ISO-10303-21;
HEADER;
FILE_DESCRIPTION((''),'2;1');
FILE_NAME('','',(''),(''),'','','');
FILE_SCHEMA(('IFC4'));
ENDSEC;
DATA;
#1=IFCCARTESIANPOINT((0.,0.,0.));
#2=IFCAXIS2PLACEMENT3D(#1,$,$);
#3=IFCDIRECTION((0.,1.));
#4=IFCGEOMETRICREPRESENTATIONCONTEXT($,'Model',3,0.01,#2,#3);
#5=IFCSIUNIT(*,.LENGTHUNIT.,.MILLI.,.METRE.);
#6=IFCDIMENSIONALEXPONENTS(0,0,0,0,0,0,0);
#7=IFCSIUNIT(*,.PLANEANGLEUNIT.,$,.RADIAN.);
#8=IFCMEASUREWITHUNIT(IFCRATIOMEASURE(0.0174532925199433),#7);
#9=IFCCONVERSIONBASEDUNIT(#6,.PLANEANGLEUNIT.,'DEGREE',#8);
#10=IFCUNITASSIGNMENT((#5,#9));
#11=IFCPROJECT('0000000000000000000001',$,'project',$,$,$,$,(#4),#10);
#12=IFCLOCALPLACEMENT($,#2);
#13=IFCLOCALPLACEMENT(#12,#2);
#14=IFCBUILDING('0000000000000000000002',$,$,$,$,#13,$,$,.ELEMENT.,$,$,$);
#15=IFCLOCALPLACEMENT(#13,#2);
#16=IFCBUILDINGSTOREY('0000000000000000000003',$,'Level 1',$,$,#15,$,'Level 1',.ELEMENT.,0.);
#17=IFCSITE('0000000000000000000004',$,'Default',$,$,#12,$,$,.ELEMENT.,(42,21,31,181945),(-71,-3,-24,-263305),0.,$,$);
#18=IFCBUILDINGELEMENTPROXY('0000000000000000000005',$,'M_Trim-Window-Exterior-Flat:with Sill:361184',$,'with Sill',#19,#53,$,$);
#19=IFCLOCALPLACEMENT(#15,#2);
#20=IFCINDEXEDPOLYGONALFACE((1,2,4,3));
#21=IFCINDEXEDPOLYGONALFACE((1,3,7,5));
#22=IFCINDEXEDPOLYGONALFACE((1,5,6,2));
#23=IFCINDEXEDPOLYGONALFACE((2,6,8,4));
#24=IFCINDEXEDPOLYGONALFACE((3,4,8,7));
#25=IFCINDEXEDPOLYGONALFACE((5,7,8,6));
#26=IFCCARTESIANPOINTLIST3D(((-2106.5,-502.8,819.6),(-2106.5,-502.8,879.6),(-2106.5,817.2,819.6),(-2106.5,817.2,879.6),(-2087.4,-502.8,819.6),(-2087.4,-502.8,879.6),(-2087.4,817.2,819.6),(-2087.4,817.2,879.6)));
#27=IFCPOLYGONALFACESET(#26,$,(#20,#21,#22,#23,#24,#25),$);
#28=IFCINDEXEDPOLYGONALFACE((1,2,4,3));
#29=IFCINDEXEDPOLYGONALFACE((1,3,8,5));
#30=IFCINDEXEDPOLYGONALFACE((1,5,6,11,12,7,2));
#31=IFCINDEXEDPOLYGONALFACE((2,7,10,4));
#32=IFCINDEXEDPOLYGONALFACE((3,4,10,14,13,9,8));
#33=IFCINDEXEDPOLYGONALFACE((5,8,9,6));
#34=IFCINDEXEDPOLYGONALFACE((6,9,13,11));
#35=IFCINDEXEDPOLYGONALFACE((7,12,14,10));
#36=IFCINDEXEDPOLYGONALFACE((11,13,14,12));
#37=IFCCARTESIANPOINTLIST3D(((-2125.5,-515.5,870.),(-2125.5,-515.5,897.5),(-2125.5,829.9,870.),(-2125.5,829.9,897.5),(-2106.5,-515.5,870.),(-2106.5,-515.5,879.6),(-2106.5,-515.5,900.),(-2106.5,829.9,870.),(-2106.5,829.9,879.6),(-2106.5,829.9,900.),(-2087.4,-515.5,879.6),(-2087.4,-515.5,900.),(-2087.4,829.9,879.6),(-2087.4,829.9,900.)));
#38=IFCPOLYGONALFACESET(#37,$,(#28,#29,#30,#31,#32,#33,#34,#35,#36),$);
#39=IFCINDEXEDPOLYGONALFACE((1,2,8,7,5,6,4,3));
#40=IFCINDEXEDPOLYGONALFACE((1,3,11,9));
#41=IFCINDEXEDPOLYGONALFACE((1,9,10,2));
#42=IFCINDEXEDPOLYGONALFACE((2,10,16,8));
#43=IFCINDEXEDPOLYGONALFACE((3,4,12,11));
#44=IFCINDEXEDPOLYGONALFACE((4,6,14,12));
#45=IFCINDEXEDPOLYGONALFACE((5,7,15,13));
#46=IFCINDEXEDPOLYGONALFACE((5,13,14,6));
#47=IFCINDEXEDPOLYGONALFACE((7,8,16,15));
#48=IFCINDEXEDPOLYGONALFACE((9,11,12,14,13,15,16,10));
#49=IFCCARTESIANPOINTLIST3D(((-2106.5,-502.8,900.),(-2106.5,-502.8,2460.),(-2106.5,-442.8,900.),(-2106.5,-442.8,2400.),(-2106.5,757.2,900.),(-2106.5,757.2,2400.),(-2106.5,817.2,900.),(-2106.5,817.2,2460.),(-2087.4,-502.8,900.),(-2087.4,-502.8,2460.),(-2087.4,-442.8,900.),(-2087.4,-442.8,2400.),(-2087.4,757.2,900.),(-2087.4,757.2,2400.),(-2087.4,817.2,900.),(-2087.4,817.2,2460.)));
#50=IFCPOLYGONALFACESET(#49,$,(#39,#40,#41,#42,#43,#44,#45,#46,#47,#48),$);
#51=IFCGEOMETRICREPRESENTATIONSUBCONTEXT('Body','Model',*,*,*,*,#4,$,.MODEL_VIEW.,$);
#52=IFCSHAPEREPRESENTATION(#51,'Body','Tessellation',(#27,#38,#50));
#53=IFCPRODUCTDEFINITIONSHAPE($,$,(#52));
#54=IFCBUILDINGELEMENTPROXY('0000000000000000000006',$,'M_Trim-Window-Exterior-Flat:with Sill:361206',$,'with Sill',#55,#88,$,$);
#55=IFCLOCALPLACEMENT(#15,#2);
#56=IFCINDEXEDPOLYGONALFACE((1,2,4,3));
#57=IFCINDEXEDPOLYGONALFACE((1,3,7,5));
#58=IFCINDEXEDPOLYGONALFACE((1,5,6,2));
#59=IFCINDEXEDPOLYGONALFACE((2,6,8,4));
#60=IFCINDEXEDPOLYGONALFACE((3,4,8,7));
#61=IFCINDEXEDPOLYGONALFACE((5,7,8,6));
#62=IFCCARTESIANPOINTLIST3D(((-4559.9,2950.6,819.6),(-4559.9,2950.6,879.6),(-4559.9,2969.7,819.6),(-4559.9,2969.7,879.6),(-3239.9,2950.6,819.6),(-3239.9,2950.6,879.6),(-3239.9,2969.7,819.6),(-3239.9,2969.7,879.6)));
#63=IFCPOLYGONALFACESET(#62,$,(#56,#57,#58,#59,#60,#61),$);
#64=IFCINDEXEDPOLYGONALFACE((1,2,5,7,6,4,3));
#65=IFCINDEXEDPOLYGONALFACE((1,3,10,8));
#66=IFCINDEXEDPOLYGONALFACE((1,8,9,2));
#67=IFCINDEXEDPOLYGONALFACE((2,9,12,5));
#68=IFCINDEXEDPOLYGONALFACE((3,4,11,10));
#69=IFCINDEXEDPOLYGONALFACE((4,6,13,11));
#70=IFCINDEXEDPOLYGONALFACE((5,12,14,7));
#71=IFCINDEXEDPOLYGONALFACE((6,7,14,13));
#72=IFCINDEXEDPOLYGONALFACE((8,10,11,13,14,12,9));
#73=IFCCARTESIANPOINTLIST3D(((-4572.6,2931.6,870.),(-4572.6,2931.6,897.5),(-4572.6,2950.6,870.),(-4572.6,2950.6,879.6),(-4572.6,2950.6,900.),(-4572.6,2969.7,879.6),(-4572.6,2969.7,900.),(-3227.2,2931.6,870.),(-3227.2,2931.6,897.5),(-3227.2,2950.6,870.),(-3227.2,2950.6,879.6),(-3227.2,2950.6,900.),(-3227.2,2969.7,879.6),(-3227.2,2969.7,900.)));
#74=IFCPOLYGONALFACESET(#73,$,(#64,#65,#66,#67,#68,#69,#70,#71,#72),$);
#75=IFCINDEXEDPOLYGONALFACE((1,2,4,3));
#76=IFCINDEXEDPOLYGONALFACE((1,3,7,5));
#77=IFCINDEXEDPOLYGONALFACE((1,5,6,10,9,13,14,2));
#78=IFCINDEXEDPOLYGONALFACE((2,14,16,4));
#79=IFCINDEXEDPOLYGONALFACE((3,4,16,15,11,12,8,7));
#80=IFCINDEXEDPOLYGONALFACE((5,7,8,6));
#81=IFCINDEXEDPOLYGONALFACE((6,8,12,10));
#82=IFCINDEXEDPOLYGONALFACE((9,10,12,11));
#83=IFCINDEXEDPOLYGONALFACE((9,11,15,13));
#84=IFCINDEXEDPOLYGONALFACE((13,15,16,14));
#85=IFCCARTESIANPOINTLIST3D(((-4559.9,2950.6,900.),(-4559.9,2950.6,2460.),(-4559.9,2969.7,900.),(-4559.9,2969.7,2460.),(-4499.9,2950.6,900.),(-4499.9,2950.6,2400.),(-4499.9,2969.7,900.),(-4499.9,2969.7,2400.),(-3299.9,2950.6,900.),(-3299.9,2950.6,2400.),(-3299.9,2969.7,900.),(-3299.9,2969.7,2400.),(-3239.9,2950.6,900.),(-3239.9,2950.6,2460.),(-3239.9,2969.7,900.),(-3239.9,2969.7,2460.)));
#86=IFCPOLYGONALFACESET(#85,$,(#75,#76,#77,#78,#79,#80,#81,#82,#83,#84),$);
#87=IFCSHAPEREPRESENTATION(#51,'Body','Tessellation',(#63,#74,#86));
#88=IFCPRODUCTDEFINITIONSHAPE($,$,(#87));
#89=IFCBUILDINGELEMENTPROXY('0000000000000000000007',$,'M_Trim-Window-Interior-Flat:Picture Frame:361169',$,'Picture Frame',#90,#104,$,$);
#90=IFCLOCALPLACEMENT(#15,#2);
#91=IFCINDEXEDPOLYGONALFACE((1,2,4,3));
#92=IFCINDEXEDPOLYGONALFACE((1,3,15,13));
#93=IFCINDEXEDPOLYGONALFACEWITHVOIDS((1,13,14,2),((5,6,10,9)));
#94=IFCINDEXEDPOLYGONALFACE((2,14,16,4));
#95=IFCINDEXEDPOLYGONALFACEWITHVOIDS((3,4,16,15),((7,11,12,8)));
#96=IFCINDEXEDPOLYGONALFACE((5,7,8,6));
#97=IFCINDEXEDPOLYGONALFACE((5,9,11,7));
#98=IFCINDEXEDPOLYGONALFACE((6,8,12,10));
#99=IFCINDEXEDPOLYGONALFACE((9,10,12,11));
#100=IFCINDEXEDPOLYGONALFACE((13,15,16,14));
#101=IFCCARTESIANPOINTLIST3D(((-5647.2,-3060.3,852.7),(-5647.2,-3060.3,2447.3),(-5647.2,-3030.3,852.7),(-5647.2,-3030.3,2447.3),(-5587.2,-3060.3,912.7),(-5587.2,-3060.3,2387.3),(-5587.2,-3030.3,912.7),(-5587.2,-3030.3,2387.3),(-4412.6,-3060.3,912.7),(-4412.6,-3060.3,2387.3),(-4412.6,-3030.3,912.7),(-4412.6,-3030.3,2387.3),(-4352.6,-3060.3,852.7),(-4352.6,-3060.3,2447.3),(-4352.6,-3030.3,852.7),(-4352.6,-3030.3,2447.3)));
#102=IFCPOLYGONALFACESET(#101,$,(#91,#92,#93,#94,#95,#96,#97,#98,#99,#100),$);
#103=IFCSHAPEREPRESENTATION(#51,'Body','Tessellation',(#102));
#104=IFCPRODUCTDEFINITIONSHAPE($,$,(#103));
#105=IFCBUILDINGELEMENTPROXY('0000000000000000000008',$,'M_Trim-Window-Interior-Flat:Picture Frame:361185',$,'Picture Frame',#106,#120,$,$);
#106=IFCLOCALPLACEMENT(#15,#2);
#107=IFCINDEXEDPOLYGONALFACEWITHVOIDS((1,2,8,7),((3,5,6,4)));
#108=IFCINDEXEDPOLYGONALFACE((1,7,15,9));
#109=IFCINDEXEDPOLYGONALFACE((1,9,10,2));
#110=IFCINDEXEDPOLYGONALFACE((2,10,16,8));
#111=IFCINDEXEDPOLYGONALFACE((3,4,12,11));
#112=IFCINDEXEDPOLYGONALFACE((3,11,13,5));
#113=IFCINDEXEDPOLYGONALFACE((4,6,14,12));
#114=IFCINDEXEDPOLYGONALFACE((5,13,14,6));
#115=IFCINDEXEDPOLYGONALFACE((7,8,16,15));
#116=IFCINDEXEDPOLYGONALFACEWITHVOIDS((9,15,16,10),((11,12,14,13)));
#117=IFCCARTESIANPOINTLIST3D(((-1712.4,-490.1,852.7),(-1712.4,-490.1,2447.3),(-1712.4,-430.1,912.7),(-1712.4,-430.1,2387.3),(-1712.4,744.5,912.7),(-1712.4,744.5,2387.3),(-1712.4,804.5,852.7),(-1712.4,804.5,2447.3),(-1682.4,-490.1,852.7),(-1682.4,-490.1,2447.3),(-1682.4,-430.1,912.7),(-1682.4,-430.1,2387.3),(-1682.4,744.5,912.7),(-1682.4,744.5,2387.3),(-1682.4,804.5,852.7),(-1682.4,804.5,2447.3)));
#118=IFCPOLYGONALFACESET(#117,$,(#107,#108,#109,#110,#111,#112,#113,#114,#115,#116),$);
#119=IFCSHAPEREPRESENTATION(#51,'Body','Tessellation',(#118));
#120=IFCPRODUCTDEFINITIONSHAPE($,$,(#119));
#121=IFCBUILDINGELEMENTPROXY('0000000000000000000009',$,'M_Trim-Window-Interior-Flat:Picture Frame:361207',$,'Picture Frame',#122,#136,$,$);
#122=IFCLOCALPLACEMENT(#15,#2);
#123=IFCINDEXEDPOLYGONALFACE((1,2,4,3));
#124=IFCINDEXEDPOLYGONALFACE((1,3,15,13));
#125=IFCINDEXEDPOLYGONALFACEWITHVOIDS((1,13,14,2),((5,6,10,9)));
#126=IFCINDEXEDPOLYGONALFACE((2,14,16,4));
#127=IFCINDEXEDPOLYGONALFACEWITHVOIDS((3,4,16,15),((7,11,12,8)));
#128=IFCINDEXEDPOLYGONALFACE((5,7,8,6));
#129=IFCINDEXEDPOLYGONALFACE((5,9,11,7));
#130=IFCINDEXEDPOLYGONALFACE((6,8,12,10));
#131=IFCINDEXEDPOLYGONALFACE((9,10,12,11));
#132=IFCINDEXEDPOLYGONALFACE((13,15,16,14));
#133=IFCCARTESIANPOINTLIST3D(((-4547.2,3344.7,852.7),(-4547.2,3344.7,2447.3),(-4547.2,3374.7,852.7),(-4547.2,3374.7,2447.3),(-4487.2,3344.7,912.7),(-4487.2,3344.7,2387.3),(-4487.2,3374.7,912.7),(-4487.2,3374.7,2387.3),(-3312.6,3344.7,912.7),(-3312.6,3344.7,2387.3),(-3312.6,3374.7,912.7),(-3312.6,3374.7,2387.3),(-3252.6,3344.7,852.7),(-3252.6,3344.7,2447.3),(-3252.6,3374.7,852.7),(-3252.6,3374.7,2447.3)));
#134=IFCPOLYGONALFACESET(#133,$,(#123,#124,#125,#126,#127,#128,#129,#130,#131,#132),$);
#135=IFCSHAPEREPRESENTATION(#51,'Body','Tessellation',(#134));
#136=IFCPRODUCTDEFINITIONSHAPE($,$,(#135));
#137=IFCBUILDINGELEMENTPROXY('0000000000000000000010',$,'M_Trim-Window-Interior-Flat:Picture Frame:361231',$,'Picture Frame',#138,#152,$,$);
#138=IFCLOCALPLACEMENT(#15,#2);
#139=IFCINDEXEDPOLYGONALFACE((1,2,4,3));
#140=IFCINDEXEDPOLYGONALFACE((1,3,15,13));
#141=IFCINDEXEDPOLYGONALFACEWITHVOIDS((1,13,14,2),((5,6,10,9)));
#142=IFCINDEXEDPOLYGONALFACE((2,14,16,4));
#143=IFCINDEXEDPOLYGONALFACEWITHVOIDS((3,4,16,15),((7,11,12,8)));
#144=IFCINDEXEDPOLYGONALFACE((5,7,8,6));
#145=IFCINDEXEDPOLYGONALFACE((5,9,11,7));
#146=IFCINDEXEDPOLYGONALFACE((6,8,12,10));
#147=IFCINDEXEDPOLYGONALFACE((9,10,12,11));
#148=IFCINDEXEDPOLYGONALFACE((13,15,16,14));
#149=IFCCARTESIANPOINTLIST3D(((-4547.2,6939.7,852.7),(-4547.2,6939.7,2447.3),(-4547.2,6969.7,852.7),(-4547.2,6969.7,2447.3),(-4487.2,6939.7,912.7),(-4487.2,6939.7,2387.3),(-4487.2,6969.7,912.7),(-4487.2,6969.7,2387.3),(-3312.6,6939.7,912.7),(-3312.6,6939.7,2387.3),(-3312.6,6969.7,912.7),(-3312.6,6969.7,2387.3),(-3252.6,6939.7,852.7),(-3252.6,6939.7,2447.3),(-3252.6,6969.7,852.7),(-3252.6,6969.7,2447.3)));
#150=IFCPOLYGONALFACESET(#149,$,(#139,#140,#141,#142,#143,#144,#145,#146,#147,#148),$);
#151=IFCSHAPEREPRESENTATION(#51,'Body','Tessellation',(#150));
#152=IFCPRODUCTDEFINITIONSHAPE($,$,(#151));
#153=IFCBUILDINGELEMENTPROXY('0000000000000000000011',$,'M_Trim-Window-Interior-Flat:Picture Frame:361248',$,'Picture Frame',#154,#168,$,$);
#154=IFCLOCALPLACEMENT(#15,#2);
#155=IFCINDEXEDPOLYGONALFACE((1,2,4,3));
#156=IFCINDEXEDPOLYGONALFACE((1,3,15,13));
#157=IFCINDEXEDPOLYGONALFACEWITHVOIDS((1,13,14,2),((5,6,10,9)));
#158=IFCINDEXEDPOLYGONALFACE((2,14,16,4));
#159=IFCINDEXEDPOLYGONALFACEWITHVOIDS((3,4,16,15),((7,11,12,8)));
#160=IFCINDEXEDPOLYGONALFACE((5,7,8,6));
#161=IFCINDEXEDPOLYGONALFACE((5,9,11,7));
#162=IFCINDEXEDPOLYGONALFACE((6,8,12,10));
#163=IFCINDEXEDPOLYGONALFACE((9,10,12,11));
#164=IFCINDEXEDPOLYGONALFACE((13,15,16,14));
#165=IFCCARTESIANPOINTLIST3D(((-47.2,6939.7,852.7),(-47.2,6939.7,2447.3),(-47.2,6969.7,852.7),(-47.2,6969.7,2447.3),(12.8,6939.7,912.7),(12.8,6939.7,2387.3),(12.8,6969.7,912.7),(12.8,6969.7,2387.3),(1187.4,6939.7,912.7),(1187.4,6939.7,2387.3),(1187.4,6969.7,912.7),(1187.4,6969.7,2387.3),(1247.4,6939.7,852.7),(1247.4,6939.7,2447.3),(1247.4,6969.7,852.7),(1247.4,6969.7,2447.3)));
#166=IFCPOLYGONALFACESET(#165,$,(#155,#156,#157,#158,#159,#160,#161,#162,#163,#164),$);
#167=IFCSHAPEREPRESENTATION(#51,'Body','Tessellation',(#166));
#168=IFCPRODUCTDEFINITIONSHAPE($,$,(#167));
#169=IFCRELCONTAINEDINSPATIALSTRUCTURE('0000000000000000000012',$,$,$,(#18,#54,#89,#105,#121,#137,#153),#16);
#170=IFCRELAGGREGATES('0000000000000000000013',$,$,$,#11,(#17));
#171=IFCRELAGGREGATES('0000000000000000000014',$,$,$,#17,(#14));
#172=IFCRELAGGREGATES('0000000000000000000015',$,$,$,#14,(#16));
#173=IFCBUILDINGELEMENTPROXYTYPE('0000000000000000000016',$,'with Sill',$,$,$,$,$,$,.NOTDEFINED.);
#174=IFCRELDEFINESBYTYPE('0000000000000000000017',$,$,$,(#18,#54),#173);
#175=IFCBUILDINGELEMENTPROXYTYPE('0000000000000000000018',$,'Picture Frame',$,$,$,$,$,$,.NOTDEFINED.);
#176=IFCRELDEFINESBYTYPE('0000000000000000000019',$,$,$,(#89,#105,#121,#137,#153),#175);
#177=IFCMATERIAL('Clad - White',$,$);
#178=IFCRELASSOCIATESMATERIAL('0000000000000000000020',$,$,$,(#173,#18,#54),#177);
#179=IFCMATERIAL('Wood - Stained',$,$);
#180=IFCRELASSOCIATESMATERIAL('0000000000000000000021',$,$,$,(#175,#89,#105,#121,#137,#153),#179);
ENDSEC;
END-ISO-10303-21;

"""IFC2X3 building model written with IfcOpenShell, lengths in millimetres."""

from ifc_helpers import new_model, entity, si_unit, converted_unit, direction, frame, frame_2d, origin, place, context, subcontext, project, spatial, polyline, rectangle, outline, extrude, source, transform, mapped, material, type_object, type_shapes, element, save


model = new_model("IFC2X3")

# Units and contexts
model_context = context("Model", 3, precision=0.01, world=origin(), true_north=direction((0.0, 1.0)))
body_context = subcontext(model_context, "Body", "Model", "MODEL_VIEW")
ifc_project = project(units=[si_unit("LENGTHUNIT", "METRE", prefix="MILLI"), converted_unit("PLANEANGLEUNIT", "DEGREE", entity("IfcRatioMeasure", 0.0174532925199433), si_unit("PLANEANGLEUNIT", "RADIAN"), dimensions=[0, 0, 0, 0, 0, 0, 0])], contexts=[model_context])

# Site, building, storey
site_placement = place(None, origin())
site = spatial("IfcSite", under=ifc_project, at=site_placement, Name="Default", CompositionType="ELEMENT", RefLatitude=(42, 21, 31, 181945), RefLongitude=(-71, -3, -24, -263305), RefElevation=0.0)
building_placement = place(site_placement, origin())
building = spatial("IfcBuilding", under=site, at=building_placement, CompositionType="ELEMENT")
storey_placement = place(building_placement, origin())
storey = spatial("IfcBuildingStorey", under=building, at=storey_placement, Name="Level 1", LongName="Level 1", CompositionType="ELEMENT", Elevation=0.0)

# Building element proxies
ifc_material_1 = material(Name="Clad - White")
ifc_material_2 = material(Name="Wood - Stained")
building_element_proxy_type_1 = type_object("IfcBuildingElementProxyType", Name="with Sill", PredefinedType="NOTDEFINED", material=ifc_material_1)
shared_shape_1 = source(origin(), body_context, "Body", "SweptSolid", [
    extrude(rectangle(XDim=1320.0, YDim=60.0, at=frame_2d((0.0, 0.0), x_axis=(1.0, 0.0))), frame((0.0, -1550.4, 0.0), z_axis=(0.0, 0.0, 1.0), x_axis=(-1.0, 0.0, 0.0)), (0.0, 0.0, 1.0), 19.1),
    extrude(outline(polyline([(-19.0, -15.2), (0.0, -15.2), (0.0, -5.7), (19.0, -5.7), (19.0, 14.8), (0.0, 14.8), (-19.0, 12.3), (-19.0, -15.2)])), frame((-672.7, -1514.8, 19.0), z_axis=(1.0, 0.0, 0.0), x_axis=(0.0, 0.0, -1.0)), (0.0, 0.0, 1.0), 1345.4),
    extrude(outline(polyline([(-795.0, -660.0), (765.0, -660.0), (765.0, -600.0), (-735.0, -600.0), (-735.0, 600.0), (765.0, 600.0), (765.0, 660.0), (-795.0, 660.0), (-795.0, -660.0)])), frame((0.0, -735.0, 0.0), z_axis=(0.0, 0.0, 1.0), x_axis=(0.0, -1.0, 0.0)), (0.0, 0.0, 1.0), 19.1),
])
type_shapes(building_element_proxy_type_1, [shared_shape_1])
for number, where, z_axis, x_axis, name in (
    (1, (-2087.4, 157.2, 2400.0), (-1.0, 0.0, 0.0), (0.0, -1.0, 0.0), "M_Trim-Window-Exterior-Flat:with Sill:361184"),
    (2, (-3899.9, 2969.7, 2400.0), (0.0, -1.0, 0.0), (1.0, 0.0, 0.0), "M_Trim-Window-Exterior-Flat:with Sill:361206"),
):
    element("IfcBuildingElementProxy", number, at=place(storey_placement, frame(where, z_axis=z_axis, x_axis=x_axis)), inside=storey, type_object=building_element_proxy_type_1, material=ifc_material_1, Name=name, ObjectType="with Sill", context=body_context, shape_type="MappedRepresentation", body=[
        mapped(shared_shape_1, transform((0.0, 0.0, 0.0), scale=1.0)),
    ])
building_element_proxy_type_2 = type_object("IfcBuildingElementProxyType", Name="Picture Frame", PredefinedType="NOTDEFINED", material=ifc_material_2)
shared_shape_2 = source(origin(), body_context, "Body", "SweptSolid", [
    extrude(outline(polyline([(-647.3, -797.3), (647.3, -797.3), (647.3, 797.3), (-647.3, 797.3), (-647.3, -797.3)]), holes=[polyline([(-587.3, -737.3), (-587.3, 737.3), (587.3, 737.3), (587.3, -737.3), (-587.3, -737.3)])]), frame((0.0, -750.0, 0.0), z_axis=(0.0, 0.0, 1.0), x_axis=(-1.0, 0.0, 0.0)), (0.0, 0.0, 1.0), 30.0),
])
type_shapes(building_element_proxy_type_2, [shared_shape_2])
for number, where, z_axis, x_axis, name in (
    (3, (-4999.9, -3030.3, 2400.0), (0.0, -1.0, 0.0), (1.0, 0.0, 0.0), "M_Trim-Window-Interior-Flat:Picture Frame:361169"),
    (4, (-1712.4, 157.2, 2400.0), (1.0, 0.0, 0.0), (0.0, 1.0, 0.0), "M_Trim-Window-Interior-Flat:Picture Frame:361185"),
    (5, (-3899.9, 3344.7, 2400.0), (0.0, 1.0, 0.0), (-1.0, 0.0, 0.0), "M_Trim-Window-Interior-Flat:Picture Frame:361207"),
    (6, (-3899.9, 6969.7, 2400.0), (0.0, -1.0, 0.0), (1.0, 0.0, 0.0), "M_Trim-Window-Interior-Flat:Picture Frame:361231"),
    (7, (600.1, 6969.7, 2400.0), (0.0, -1.0, 0.0), (1.0, 0.0, 0.0), "M_Trim-Window-Interior-Flat:Picture Frame:361248"),
):
    element("IfcBuildingElementProxy", number, at=place(storey_placement, frame(where, z_axis=z_axis, x_axis=x_axis)), inside=storey, type_object=building_element_proxy_type_2, material=ifc_material_2, Name=name, ObjectType="Picture Frame", context=body_context, shape_type="MappedRepresentation", body=[
        mapped(shared_shape_2, transform((0.0, 0.0, 0.0), scale=1.0)),
    ])

save(model, "model.ifc")
